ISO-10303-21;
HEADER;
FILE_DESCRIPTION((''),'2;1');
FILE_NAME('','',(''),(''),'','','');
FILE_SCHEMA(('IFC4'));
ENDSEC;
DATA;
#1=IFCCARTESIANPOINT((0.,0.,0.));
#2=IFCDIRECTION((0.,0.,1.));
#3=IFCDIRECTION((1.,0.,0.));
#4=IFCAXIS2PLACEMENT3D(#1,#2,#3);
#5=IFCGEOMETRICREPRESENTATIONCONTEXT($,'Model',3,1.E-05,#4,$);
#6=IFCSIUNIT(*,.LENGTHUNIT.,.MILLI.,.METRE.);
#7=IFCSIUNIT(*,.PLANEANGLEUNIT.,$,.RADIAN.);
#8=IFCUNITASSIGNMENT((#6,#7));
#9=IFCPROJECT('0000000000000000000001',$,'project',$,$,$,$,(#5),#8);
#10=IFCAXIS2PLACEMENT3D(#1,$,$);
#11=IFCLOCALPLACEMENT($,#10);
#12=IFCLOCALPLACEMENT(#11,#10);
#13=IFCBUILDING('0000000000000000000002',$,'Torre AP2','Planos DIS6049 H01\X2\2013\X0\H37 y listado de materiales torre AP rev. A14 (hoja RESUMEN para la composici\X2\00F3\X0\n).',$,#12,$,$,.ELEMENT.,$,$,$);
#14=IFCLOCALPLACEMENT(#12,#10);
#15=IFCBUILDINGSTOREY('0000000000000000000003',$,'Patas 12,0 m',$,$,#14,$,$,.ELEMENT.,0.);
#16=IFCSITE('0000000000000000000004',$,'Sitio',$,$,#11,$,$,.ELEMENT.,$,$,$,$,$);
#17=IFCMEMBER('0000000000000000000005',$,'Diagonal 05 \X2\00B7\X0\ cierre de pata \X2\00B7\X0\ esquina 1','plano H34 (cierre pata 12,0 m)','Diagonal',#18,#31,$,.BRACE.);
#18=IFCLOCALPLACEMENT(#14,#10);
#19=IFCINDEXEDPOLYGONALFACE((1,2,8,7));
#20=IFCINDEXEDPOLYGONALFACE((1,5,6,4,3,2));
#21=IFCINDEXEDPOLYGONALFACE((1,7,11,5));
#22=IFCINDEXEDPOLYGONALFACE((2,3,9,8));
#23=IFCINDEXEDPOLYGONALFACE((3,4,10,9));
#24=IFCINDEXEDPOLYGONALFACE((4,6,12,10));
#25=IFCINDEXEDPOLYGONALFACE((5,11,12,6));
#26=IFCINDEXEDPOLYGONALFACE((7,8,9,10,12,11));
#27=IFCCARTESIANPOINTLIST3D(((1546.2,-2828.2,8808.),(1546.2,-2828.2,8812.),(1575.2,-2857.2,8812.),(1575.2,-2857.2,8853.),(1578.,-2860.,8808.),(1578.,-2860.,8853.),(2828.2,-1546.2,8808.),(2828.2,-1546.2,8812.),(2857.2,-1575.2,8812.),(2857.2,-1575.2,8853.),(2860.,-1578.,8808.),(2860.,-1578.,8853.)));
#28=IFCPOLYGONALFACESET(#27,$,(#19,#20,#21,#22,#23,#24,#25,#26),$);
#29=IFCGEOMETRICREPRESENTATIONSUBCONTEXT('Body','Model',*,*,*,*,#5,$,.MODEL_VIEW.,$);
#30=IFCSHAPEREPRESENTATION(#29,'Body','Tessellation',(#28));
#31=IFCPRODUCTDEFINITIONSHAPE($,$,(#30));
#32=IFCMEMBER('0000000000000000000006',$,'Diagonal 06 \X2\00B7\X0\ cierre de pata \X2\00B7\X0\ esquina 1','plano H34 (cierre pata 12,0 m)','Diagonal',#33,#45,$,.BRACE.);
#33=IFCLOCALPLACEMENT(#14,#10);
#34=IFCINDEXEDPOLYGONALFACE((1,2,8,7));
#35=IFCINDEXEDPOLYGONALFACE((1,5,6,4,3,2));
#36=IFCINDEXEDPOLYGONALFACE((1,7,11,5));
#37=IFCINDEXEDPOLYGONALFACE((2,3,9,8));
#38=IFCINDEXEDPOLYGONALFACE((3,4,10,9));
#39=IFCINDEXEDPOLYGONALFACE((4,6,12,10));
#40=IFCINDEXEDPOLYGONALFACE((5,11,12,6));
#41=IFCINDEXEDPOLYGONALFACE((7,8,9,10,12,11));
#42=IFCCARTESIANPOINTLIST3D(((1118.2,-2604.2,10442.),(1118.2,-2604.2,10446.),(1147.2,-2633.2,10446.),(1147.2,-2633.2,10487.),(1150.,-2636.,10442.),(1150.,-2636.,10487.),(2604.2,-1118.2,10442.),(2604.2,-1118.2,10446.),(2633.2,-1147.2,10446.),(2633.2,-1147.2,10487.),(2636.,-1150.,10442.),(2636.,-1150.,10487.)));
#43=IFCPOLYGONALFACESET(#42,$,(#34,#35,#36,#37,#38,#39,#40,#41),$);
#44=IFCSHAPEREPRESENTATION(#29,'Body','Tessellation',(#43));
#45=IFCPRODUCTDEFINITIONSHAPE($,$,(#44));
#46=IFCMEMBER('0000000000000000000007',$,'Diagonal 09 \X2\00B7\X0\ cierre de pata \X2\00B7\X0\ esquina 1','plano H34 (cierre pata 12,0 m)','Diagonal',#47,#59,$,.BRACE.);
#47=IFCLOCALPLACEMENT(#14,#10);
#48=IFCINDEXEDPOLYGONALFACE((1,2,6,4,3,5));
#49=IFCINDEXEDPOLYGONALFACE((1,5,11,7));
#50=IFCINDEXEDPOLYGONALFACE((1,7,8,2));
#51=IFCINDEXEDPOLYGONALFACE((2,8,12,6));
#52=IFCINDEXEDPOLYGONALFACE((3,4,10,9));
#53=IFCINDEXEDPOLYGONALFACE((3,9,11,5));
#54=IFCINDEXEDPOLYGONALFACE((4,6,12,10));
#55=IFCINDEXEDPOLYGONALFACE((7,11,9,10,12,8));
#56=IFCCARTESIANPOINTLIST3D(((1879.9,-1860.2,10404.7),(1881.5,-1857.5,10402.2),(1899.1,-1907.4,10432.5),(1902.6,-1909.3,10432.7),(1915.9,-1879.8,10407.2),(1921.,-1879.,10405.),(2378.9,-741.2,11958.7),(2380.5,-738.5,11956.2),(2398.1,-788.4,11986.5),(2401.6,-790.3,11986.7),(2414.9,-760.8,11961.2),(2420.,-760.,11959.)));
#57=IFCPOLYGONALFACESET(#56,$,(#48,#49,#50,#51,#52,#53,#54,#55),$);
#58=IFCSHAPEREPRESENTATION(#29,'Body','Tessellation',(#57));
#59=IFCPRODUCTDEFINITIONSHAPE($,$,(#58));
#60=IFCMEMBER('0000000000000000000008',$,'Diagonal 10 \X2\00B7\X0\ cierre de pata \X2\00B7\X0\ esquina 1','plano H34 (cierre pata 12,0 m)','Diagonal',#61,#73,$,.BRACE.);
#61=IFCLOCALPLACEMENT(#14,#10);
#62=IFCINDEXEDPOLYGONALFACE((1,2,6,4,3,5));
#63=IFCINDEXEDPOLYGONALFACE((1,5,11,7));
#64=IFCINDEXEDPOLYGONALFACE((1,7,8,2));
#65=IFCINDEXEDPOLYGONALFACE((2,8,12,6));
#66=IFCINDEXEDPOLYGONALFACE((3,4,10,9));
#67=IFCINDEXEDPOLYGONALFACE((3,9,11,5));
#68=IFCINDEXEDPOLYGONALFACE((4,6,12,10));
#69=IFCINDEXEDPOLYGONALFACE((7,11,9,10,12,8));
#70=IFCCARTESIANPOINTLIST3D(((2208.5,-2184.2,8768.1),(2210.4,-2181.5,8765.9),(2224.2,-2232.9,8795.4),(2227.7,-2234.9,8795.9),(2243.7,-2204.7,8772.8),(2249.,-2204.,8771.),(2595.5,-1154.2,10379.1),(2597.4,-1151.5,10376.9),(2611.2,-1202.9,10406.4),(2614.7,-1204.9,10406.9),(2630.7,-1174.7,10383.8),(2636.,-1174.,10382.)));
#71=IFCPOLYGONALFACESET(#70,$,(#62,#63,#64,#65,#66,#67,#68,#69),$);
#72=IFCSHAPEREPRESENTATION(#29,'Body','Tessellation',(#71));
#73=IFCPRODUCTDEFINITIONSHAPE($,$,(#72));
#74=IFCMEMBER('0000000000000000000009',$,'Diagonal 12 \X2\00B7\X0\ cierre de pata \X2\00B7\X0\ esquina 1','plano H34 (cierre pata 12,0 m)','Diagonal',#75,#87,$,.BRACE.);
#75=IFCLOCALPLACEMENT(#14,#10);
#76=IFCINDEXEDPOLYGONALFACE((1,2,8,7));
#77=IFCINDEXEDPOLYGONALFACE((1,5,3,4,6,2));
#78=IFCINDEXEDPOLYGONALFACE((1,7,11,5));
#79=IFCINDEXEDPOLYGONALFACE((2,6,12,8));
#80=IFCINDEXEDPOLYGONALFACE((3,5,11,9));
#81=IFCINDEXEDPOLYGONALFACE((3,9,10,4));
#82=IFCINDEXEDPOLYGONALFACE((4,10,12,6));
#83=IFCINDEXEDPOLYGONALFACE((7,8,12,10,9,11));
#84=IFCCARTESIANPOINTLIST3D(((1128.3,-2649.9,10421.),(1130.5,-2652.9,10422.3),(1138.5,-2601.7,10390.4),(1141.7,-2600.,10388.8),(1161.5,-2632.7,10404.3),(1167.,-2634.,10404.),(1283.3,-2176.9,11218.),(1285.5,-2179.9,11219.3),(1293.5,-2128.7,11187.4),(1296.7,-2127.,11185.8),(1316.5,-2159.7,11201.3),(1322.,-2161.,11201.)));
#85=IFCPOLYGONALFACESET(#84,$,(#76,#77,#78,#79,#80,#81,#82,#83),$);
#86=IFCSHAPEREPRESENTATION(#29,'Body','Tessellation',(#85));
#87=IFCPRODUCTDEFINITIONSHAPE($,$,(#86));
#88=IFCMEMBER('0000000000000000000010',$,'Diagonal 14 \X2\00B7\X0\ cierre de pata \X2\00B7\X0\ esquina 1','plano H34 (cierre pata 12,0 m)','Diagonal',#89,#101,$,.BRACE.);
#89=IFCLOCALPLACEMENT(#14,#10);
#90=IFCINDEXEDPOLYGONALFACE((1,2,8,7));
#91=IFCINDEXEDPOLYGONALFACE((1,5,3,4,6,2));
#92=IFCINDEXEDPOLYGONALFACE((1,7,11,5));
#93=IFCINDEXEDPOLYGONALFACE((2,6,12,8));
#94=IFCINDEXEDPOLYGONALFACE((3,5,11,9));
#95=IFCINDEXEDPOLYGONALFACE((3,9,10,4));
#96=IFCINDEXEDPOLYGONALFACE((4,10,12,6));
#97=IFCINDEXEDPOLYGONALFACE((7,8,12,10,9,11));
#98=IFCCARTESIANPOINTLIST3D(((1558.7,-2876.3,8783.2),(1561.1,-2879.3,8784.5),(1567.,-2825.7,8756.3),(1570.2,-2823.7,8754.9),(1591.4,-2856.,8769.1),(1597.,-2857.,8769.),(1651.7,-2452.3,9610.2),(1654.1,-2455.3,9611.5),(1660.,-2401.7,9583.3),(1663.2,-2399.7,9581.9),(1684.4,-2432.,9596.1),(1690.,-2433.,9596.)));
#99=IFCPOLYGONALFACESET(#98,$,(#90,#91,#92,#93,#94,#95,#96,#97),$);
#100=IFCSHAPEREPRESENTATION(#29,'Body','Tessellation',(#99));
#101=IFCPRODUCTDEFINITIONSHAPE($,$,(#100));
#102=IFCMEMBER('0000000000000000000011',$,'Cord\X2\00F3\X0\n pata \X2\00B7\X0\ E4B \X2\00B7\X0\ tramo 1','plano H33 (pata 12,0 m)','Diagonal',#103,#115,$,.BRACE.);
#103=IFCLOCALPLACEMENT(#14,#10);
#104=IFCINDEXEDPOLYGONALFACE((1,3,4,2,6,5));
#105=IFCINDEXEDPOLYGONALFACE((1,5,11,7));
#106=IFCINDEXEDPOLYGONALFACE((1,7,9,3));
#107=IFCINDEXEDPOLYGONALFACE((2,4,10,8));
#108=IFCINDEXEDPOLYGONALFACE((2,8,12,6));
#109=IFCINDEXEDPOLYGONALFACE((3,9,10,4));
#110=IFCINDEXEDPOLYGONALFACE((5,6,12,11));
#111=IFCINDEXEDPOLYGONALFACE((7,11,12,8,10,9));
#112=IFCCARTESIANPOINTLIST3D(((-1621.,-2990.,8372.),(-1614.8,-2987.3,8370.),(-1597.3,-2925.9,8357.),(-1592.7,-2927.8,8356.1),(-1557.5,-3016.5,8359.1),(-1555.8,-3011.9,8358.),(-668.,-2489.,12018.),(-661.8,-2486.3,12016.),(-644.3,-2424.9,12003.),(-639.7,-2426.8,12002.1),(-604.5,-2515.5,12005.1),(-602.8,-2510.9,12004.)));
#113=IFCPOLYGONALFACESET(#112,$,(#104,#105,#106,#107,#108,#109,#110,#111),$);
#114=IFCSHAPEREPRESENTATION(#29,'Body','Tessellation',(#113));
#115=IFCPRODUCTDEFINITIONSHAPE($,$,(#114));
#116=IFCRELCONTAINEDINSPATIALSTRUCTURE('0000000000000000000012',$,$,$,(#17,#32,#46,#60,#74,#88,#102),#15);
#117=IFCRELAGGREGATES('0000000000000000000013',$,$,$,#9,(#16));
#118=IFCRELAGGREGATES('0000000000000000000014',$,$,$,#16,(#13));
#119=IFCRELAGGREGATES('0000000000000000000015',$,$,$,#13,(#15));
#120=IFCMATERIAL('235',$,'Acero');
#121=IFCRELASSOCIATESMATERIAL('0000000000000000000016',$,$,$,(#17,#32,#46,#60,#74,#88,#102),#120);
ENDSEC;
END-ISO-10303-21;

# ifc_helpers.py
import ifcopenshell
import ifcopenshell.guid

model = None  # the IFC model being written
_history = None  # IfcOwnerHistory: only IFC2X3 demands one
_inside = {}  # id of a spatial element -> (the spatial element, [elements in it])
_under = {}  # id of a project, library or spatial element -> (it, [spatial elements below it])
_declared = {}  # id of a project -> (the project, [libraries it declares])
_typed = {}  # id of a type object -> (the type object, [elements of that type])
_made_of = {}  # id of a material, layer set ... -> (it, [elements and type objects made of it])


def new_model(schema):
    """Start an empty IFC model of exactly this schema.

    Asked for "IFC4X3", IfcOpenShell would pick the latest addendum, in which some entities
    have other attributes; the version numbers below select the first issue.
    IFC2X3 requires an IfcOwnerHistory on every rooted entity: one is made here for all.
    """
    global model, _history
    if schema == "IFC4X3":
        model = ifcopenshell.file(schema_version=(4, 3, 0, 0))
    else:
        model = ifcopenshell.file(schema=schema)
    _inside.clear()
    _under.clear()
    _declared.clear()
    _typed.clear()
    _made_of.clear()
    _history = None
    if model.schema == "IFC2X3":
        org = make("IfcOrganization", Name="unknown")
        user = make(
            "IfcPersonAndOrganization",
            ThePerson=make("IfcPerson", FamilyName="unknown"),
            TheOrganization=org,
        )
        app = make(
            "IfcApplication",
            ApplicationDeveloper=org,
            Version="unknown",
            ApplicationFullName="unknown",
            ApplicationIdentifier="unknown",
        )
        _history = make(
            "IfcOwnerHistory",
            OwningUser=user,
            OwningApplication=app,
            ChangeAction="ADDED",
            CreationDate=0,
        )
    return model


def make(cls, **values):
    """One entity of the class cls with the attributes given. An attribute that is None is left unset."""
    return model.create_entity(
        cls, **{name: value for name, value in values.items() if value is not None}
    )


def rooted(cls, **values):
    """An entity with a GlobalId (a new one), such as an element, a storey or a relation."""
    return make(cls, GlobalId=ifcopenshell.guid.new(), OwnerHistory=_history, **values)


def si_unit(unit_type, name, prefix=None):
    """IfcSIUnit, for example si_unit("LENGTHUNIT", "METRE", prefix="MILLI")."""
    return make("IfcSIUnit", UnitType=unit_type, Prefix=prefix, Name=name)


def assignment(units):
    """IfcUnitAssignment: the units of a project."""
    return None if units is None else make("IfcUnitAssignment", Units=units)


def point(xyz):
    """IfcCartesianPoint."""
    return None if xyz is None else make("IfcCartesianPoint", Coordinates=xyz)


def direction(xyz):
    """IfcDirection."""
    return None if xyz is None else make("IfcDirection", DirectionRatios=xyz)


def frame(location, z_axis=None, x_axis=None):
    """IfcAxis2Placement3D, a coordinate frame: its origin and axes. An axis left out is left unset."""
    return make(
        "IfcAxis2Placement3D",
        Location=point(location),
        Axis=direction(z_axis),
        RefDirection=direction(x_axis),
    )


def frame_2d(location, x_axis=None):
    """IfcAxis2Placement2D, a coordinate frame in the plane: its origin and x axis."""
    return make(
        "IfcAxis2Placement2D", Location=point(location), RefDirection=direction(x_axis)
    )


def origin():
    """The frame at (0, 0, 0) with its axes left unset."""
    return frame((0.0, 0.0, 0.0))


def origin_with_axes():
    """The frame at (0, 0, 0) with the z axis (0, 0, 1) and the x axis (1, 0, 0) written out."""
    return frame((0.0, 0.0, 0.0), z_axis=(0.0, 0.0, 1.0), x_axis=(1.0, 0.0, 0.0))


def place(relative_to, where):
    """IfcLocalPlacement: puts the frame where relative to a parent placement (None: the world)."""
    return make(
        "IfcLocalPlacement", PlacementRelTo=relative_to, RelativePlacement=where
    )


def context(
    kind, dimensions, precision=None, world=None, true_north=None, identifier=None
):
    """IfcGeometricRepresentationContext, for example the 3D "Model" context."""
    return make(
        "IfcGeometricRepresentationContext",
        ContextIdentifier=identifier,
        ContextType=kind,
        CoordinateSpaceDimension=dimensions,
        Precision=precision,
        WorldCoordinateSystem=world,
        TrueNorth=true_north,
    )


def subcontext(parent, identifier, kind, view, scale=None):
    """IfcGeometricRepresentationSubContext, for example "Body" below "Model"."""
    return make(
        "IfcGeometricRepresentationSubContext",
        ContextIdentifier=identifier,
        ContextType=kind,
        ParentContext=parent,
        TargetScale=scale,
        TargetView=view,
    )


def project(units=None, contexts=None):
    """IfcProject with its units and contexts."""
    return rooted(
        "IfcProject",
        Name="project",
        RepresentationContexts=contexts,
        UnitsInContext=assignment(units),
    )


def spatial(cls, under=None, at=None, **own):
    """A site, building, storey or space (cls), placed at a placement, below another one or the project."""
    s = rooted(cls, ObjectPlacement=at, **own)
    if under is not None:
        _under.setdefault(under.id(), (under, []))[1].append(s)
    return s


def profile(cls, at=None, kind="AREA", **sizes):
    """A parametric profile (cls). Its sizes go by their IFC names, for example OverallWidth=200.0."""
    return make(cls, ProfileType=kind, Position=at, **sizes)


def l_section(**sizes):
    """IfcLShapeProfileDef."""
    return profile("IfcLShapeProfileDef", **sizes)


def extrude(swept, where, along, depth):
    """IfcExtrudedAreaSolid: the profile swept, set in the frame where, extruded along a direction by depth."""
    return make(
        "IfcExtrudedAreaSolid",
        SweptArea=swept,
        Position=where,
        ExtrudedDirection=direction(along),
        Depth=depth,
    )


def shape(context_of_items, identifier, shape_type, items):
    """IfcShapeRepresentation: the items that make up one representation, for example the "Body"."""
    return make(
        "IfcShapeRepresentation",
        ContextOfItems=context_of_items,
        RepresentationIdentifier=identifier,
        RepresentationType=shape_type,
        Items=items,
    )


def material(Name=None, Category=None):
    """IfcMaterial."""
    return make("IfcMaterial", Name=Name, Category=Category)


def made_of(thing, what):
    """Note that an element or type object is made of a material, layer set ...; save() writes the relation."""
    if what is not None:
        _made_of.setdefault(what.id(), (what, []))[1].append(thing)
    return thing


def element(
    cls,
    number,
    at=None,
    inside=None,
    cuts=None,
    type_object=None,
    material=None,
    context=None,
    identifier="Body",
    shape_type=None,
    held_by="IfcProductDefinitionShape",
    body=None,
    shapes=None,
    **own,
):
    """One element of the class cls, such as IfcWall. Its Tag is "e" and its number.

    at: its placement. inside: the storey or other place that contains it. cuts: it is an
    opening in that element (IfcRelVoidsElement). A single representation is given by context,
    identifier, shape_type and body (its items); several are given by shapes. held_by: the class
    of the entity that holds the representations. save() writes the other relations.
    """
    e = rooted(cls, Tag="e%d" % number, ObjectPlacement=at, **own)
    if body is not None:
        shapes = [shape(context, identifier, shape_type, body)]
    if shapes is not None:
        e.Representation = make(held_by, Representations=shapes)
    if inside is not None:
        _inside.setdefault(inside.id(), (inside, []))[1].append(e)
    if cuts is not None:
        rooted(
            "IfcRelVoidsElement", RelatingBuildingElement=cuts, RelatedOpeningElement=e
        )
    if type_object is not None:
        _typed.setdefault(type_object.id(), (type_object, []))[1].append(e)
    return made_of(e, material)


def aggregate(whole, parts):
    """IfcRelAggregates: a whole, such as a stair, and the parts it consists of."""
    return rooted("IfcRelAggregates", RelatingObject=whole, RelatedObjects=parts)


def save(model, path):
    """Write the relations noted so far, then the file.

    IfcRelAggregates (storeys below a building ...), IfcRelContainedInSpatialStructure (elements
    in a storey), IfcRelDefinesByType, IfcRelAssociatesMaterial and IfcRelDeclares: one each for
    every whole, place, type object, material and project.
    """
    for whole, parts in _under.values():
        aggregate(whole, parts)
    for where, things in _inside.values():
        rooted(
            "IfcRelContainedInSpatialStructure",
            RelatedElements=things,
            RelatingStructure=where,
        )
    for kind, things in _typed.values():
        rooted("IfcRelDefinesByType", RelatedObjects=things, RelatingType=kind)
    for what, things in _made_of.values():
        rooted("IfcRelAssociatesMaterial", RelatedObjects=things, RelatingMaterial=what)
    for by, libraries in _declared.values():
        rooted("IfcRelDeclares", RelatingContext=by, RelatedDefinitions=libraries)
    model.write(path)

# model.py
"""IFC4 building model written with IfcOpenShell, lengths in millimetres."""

from ifc_helpers import new_model, si_unit, frame, frame_2d, origin, origin_with_axes, place, context, subcontext, project, spatial, l_section, extrude, material, element, save


model = new_model("IFC4")

# Units and contexts
model_context = context("Model", 3, precision=1e-05, world=origin_with_axes())
body_context = subcontext(model_context, "Body", "Model", "MODEL_VIEW")
ifc_project = project(units=[si_unit("LENGTHUNIT", "METRE", prefix="MILLI"), si_unit("PLANEANGLEUNIT", "RADIAN")], contexts=[model_context])

# Site, building, storey
site_placement = place(None, origin())
site = spatial("IfcSite", under=ifc_project, at=site_placement, Name="Sitio", CompositionType="ELEMENT")
building_placement = place(site_placement, origin())
building = spatial("IfcBuilding", under=site, at=building_placement, Name="Torre AP2", Description="Planos DIS6049 H01–H37 y listado de materiales torre AP rev. A14 (hoja RESUMEN para la composición).", CompositionType="ELEMENT")
storey_placement = place(building_placement, origin())
storey = spatial("IfcBuildingStorey", under=building, at=storey_placement, Name="Patas 12,0 m", CompositionType="ELEMENT", Elevation=0.0)

# Members
ifc_material_1 = material(Name="235", Category="Acero")
member_1_placement = place(storey_placement, frame((1578.0, -2860.0, 8808.0), z_axis=(0.707107, 0.707107, 0.0), x_axis=(-0.707107, 0.707107, 0.0)))
element("IfcMember", 1, at=member_1_placement, inside=storey, material=ifc_material_1, Name="Diagonal 05 · cierre de pata · esquina 1", Description="plano H34 (cierre pata 12,0 m)", ObjectType="Diagonal", PredefinedType="BRACE", context=body_context, shape_type="SweptSolid", body=[
    extrude(l_section(Depth=45.0, Width=45.0, Thickness=4.0, at=frame_2d((22.5, 22.5))), None, (0.0, 0.0, 1.0), 1813.0),
])
member_2_placement = place(storey_placement, frame((1150.0, -2636.0, 10442.0), z_axis=(0.707107, 0.707107, 0.0), x_axis=(-0.707107, 0.707107, 0.0)))
element("IfcMember", 2, at=member_2_placement, inside=storey, material=ifc_material_1, Name="Diagonal 06 · cierre de pata · esquina 1", Description="plano H34 (cierre pata 12,0 m)", ObjectType="Diagonal", PredefinedType="BRACE", context=body_context, shape_type="SweptSolid", body=[
    extrude(l_section(Depth=45.0, Width=45.0, Thickness=4.0, at=frame_2d((22.5, 22.5))), None, (0.0, 0.0, 1.0), 2101.5),
])
member_3_placement = place(storey_placement, frame((1921.0, -1879.0, 10405.0), z_axis=(0.252159, 0.565463, 0.785281), x_axis=(-0.876918, 0.476669, -0.061654)))
element("IfcMember", 3, at=member_3_placement, inside=storey, material=ifc_material_1, Name="Diagonal 09 · cierre de pata · esquina 1", Description="plano H34 (cierre pata 12,0 m)", ObjectType="Diagonal", PredefinedType="BRACE", context=body_context, shape_type="SweptSolid", body=[
    extrude(l_section(Depth=45.0, Width=45.0, Thickness=4.0, at=frame_2d((22.5, 22.5))), None, (0.0, 0.0, 1.0), 1978.9),
])
member_4_placement = place(storey_placement, frame((2249.0, -2204.0, 8771.0), z_axis=(0.198371, 0.527963, 0.825775), x_axis=(-0.857806, 0.5011, -0.114315)))
element("IfcMember", 4, at=member_4_placement, inside=storey, material=ifc_material_1, Name="Diagonal 10 · cierre de pata · esquina 1", Description="plano H34 (cierre pata 12,0 m)", ObjectType="Diagonal", PredefinedType="BRACE", context=body_context, shape_type="SweptSolid", body=[
    extrude(l_section(Depth=45.0, Width=45.0, Thickness=4.0, at=frame_2d((22.5, 22.5))), None, (0.0, 0.0, 1.0), 1950.9),
])
member_5_placement = place(storey_placement, frame((1167.0, -2634.0, 10404.0), z_axis=(0.164953, 0.503373, 0.848178), x_axis=(-0.561924, 0.754706, -0.338617)))
element("IfcMember", 5, at=member_5_placement, inside=storey, material=ifc_material_1, Name="Diagonal 12 · cierre de pata · esquina 1", Description="plano H34 (cierre pata 12,0 m)", ObjectType="Diagonal", PredefinedType="BRACE", context=body_context, shape_type="SweptSolid", body=[
    extrude(l_section(Depth=45.0, Width=45.0, Thickness=4.0, at=frame_2d((22.5, 22.5))), None, (0.0, 0.0, 1.0), 939.7),
])
member_6_placement = place(storey_placement, frame((1597.0, -2857.0, 8769.0), z_axis=(0.099572, 0.453962, 0.88544), x_axis=(-0.594896, 0.740469, -0.312737)))
element("IfcMember", 6, at=member_6_placement, inside=storey, material=ifc_material_1, Name="Diagonal 14 · cierre de pata · esquina 1", Description="plano H34 (cierre pata 12,0 m)", ObjectType="Diagonal", PredefinedType="BRACE", context=body_context, shape_type="SweptSolid", body=[
    extrude(l_section(Depth=45.0, Width=45.0, Thickness=4.0, at=frame_2d((22.5, 22.5))), None, (0.0, 0.0, 1.0), 934.0),
])
member_7_placement = place(storey_placement, frame((-668.0, -2489.0, 12018.0), z_axis=(-0.250681, -0.131785, -0.959058), x_axis=(0.338951, 0.916032, -0.214469)))
element("IfcMember", 7, at=member_7_placement, inside=storey, material=ifc_material_1, Name="Cordón pata · E4B · tramo 1", Description="plano H33 (pata 12,0 m)", ObjectType="Diagonal", PredefinedType="BRACE", context=body_context, shape_type="SweptSolid", body=[
    extrude(l_section(Depth=70.0, Width=70.0, Thickness=5.0, at=frame_2d((35.0, 35.0))), None, (0.0, 0.0, 1.0), 3801.6),
])

save(model, "model.ifc")
